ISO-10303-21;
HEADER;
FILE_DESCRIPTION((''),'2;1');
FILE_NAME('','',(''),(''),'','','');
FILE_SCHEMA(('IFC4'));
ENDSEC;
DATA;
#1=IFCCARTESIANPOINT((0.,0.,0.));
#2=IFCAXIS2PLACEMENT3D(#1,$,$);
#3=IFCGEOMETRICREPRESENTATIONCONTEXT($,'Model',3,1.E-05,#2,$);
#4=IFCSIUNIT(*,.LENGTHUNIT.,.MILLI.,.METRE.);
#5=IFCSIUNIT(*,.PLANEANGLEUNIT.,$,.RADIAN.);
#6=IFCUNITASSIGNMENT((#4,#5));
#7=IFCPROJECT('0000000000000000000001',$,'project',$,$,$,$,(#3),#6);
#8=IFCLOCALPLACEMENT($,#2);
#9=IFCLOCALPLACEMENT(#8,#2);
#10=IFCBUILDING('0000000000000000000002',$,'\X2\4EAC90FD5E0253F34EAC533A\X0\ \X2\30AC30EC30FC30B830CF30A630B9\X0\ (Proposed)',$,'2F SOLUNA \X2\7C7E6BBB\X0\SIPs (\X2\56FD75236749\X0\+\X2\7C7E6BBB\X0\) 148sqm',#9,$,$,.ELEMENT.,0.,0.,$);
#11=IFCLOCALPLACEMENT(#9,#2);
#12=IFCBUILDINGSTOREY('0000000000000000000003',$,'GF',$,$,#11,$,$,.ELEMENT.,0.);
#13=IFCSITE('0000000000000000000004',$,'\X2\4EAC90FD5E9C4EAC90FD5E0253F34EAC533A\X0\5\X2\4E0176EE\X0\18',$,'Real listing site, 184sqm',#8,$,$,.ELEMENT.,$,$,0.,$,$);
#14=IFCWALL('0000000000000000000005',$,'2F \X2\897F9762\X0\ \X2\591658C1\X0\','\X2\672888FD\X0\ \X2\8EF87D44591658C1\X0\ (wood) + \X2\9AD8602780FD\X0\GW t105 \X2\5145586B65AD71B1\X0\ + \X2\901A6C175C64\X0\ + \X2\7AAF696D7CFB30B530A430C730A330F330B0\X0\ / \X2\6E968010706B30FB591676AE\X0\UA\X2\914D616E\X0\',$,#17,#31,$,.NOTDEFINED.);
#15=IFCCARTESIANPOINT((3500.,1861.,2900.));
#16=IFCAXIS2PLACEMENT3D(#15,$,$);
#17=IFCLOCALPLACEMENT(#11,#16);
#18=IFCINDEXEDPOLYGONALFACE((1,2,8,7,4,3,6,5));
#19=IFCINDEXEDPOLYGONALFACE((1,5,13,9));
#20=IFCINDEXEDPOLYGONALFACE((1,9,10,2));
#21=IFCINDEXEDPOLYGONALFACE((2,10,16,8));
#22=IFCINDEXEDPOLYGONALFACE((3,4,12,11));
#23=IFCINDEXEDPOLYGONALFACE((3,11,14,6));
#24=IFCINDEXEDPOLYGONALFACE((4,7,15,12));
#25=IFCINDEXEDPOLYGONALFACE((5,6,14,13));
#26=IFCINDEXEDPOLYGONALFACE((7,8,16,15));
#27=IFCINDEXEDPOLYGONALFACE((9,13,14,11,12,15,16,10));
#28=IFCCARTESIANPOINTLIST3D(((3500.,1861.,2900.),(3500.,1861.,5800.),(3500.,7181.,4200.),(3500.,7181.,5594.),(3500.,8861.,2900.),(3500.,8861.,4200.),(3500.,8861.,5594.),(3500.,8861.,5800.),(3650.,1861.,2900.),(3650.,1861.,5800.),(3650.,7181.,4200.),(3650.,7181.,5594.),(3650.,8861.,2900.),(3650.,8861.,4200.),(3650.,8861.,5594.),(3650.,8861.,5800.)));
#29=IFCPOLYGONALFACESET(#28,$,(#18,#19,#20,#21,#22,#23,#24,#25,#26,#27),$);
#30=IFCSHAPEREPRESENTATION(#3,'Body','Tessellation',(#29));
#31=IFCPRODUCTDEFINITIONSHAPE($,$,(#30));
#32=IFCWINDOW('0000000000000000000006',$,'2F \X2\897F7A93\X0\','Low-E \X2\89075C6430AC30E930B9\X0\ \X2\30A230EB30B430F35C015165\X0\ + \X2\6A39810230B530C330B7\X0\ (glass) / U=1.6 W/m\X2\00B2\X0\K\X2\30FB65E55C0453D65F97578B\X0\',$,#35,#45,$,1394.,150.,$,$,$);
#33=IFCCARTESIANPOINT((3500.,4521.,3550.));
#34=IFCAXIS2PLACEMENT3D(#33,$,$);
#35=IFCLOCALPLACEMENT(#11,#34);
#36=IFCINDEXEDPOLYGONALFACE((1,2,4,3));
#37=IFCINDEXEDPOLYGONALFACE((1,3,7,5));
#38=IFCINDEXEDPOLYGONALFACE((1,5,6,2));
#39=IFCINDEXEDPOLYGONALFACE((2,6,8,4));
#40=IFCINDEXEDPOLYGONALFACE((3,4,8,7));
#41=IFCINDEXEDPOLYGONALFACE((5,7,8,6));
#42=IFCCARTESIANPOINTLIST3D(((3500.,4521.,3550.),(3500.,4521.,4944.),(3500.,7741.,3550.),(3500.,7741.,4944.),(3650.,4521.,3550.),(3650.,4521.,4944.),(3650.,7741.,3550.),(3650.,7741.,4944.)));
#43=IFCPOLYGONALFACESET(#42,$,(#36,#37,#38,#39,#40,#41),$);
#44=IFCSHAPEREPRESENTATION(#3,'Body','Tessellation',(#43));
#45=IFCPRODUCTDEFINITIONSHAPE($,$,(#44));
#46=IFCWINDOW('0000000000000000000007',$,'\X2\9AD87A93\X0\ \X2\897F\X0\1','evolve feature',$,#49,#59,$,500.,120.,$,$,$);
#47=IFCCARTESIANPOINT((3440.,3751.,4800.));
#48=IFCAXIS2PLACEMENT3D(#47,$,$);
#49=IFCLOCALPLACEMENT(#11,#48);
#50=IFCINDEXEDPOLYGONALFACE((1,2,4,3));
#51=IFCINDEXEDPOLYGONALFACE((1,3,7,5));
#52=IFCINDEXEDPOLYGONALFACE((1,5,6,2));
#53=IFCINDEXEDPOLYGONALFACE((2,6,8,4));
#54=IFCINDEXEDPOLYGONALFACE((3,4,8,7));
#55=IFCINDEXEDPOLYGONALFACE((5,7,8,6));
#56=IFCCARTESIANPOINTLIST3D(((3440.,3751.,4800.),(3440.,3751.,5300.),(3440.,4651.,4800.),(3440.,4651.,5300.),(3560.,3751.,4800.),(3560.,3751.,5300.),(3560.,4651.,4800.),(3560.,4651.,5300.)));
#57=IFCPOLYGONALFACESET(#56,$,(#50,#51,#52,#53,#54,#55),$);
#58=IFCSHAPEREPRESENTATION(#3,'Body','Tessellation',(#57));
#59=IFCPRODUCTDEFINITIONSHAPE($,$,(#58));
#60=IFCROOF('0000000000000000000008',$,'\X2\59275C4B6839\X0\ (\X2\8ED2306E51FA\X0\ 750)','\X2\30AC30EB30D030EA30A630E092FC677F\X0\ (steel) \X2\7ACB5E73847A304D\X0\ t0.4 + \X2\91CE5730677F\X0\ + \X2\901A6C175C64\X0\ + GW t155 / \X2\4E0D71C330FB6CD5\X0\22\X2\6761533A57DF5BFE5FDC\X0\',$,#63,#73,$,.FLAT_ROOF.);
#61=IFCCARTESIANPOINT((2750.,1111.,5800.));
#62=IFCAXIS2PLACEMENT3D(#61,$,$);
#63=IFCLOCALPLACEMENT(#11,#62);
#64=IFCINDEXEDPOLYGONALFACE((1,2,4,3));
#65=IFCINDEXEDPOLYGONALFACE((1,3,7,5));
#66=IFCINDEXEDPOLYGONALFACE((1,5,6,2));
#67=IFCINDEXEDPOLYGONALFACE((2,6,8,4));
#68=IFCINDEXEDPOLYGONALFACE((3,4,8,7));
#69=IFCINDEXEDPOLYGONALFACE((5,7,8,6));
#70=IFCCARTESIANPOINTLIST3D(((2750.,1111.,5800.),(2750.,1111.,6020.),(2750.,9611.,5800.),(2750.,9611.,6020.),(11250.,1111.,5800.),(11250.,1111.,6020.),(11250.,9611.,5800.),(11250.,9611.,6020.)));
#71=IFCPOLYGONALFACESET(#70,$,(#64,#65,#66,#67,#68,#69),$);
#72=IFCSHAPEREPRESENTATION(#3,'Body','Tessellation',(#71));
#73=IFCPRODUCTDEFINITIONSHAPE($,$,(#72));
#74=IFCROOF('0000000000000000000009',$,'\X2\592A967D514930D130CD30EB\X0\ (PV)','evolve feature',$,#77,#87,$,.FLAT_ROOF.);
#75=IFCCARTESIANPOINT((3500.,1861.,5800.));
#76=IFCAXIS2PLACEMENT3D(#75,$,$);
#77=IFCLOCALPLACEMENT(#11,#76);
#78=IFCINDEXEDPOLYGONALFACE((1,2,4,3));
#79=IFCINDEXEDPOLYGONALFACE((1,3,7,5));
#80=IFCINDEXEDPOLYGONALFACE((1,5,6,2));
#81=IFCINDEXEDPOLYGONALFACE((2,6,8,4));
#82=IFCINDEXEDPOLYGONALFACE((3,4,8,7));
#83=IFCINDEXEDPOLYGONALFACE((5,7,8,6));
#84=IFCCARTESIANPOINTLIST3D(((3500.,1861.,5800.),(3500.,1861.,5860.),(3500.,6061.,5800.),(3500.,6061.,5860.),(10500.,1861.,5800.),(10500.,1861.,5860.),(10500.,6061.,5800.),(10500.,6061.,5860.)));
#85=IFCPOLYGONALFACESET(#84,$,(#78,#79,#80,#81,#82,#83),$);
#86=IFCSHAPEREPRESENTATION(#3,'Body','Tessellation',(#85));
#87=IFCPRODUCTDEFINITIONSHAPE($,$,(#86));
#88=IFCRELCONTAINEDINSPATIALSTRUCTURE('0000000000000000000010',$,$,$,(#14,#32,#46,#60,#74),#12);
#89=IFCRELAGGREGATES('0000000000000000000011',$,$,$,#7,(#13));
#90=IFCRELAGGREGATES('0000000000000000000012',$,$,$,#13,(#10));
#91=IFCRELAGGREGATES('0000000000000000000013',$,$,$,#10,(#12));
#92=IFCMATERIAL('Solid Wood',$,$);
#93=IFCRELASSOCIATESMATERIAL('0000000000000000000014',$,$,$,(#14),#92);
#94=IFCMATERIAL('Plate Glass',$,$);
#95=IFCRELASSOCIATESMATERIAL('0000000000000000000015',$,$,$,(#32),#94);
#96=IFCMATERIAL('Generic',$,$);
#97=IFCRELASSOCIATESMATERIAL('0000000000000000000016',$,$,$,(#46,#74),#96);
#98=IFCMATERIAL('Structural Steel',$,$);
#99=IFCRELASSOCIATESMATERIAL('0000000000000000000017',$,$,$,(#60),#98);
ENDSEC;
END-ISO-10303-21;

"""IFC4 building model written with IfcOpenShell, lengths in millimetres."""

from ifc_helpers import new_model, si_unit, frame, frame_2d, origin, place, context, project, spatial, rectangle, extrude, material, element, fill, save


model = new_model("IFC4")

# Units and contexts
model_context = context("Model", 3, precision=1e-05, world=origin())
ifc_project = project(units=[si_unit("LENGTHUNIT", "METRE", prefix="MILLI"), si_unit("PLANEANGLEUNIT", "RADIAN")], contexts=[model_context])

# Site, building, storey
site_placement = place(None, origin())
site = spatial("IfcSite", under=ifc_project, at=site_placement, Name="京都府京都市右京区5丁目18", ObjectType="Real listing site, 184sqm", CompositionType="ELEMENT", RefElevation=0.0)
building_placement = place(site_placement, origin())
building = spatial("IfcBuilding", under=site, at=building_placement, Name="京都市右京区 ガレージハウス (Proposed)", ObjectType="2F SOLUNA 籾殻SIPs (国産杉+籾殻) 148sqm", CompositionType="ELEMENT", ElevationOfRefHeight=0.0, ElevationOfTerrain=0.0)
storey_placement = place(building_placement, origin())
storey = spatial("IfcBuildingStorey", under=building, at=storey_placement, Name="GF", CompositionType="ELEMENT", Elevation=0.0)

# Shared definitions
ifc_material_1 = material(Name="Solid Wood")
ifc_material_2 = material(Name="Generic")

# Shared definitions
ifc_material_3 = material(Name="Plate Glass")

# Wall, openings, windows
wall_1_placement = place(storey_placement, frame((3500.0, 1861.0, 2900.0)))
wall_1 = element("IfcWall", 1, at=wall_1_placement, inside=storey, material=ifc_material_1, Name="2F 西面 外壁", Description="木製 軸組外壁 (wood) + 高性能GW t105 充填断熱 + 通気層 + 窯業系サイディング / 準耐火・外皮UA配慮", PredefinedType="NOTDEFINED", context=model_context, shape_type="SweptSolid", body=[
    extrude(rectangle(XDim=150.0, YDim=7000.0, at=frame_2d((75.0, 3500.0))), frame((3500.0, 1861.0, 2900.0)), (0.0, 0.0, 1.0), 2900.0),
])
opening_1_placement = place(storey_placement, frame((3500.0, 4521.0, 3550.0)))
opening_1 = element("IfcOpeningElement", 2, at=opening_1_placement, cuts=wall_1, PredefinedType="NOTDEFINED", context=model_context, shape_type="SweptSolid", body=[
    extrude(rectangle(XDim=150.0, YDim=3220.0, at=frame_2d((75.0, 1610.0))), frame((3500.0, 4521.0, 3550.0)), (0.0, 0.0, 1.0), 1394.0),
])
opening_2_placement = place(storey_placement, frame((3440.0, 3751.0, 4800.0)))
opening_2 = element("IfcOpeningElement", 3, at=opening_2_placement, cuts=wall_1, PredefinedType="NOTDEFINED", context=model_context, shape_type="SweptSolid", body=[
    extrude(rectangle(XDim=120.0, YDim=900.0, at=frame_2d((60.0, 450.0))), frame((3440.0, 3751.0, 4800.0)), (0.0, 0.0, 1.0), 500.0),
])
window_1_placement = place(storey_placement, frame((3500.0, 4521.0, 3550.0)))
window_1 = element("IfcWindow", 4, at=window_1_placement, inside=storey, material=ifc_material_3, Name="2F 西窓", Description="Low-E 複層ガラス アルゴン封入 + 樹脂サッシ (glass) / U=1.6 W/m²K・日射取得型", OverallHeight=1394.0, OverallWidth=150.0, context=model_context, shape_type="SweptSolid", body=[
    extrude(rectangle(XDim=150.0, YDim=3220.0, at=frame_2d((75.0, 1610.0))), frame((3500.0, 4521.0, 3550.0)), (0.0, 0.0, 1.0), 1394.0),
])
fill(opening_1, window_1)
window_2_placement = place(storey_placement, frame((3440.0, 3751.0, 4800.0)))
window_2 = element("IfcWindow", 5, at=window_2_placement, inside=storey, material=ifc_material_2, Name="高窓 西1", Description="evolve feature", OverallHeight=500.0, OverallWidth=120.0, context=model_context, shape_type="SweptSolid", body=[
    extrude(rectangle(XDim=120.0, YDim=900.0, at=frame_2d((60.0, 450.0))), frame((3440.0, 3751.0, 4800.0)), (0.0, 0.0, 1.0), 500.0),
])
fill(opening_2, window_2)

# Roofs
ifc_material_4 = material(Name="Structural Steel")
roof_1_placement = place(storey_placement, frame((2750.0, 1111.0, 5800.0)))
element("IfcRoof", 6, at=roof_1_placement, inside=storey, material=ifc_material_4, Name="大屋根 (軒の出 750)", Description="ガルバリウム鋼板 (steel) 立平葺き t0.4 + 野地板 + 通気層 + GW t155 / 不燃・法22条区域対応", PredefinedType="FLAT_ROOF", context=model_context, shape_type="SweptSolid", body=[
    extrude(rectangle(XDim=8500.0, YDim=8500.0, at=frame_2d((4250.0, 4250.0))), frame((2750.0, 1111.0, 5800.0)), (0.0, 0.0, 1.0), 220.0),
])
roof_2_placement = place(storey_placement, frame((3500.0, 1861.0, 5800.0)))
element("IfcRoof", 7, at=roof_2_placement, inside=storey, material=ifc_material_2, Name="太陽光パネル (PV)", Description="evolve feature", PredefinedType="FLAT_ROOF", context=model_context, shape_type="SweptSolid", body=[
    extrude(rectangle(XDim=7000.0, YDim=4200.0, at=frame_2d((3500.0, 2100.0))), frame((3500.0, 1861.0, 5800.0)), (0.0, 0.0, 1.0), 60.0),
])

save(model, "model.ifc")
